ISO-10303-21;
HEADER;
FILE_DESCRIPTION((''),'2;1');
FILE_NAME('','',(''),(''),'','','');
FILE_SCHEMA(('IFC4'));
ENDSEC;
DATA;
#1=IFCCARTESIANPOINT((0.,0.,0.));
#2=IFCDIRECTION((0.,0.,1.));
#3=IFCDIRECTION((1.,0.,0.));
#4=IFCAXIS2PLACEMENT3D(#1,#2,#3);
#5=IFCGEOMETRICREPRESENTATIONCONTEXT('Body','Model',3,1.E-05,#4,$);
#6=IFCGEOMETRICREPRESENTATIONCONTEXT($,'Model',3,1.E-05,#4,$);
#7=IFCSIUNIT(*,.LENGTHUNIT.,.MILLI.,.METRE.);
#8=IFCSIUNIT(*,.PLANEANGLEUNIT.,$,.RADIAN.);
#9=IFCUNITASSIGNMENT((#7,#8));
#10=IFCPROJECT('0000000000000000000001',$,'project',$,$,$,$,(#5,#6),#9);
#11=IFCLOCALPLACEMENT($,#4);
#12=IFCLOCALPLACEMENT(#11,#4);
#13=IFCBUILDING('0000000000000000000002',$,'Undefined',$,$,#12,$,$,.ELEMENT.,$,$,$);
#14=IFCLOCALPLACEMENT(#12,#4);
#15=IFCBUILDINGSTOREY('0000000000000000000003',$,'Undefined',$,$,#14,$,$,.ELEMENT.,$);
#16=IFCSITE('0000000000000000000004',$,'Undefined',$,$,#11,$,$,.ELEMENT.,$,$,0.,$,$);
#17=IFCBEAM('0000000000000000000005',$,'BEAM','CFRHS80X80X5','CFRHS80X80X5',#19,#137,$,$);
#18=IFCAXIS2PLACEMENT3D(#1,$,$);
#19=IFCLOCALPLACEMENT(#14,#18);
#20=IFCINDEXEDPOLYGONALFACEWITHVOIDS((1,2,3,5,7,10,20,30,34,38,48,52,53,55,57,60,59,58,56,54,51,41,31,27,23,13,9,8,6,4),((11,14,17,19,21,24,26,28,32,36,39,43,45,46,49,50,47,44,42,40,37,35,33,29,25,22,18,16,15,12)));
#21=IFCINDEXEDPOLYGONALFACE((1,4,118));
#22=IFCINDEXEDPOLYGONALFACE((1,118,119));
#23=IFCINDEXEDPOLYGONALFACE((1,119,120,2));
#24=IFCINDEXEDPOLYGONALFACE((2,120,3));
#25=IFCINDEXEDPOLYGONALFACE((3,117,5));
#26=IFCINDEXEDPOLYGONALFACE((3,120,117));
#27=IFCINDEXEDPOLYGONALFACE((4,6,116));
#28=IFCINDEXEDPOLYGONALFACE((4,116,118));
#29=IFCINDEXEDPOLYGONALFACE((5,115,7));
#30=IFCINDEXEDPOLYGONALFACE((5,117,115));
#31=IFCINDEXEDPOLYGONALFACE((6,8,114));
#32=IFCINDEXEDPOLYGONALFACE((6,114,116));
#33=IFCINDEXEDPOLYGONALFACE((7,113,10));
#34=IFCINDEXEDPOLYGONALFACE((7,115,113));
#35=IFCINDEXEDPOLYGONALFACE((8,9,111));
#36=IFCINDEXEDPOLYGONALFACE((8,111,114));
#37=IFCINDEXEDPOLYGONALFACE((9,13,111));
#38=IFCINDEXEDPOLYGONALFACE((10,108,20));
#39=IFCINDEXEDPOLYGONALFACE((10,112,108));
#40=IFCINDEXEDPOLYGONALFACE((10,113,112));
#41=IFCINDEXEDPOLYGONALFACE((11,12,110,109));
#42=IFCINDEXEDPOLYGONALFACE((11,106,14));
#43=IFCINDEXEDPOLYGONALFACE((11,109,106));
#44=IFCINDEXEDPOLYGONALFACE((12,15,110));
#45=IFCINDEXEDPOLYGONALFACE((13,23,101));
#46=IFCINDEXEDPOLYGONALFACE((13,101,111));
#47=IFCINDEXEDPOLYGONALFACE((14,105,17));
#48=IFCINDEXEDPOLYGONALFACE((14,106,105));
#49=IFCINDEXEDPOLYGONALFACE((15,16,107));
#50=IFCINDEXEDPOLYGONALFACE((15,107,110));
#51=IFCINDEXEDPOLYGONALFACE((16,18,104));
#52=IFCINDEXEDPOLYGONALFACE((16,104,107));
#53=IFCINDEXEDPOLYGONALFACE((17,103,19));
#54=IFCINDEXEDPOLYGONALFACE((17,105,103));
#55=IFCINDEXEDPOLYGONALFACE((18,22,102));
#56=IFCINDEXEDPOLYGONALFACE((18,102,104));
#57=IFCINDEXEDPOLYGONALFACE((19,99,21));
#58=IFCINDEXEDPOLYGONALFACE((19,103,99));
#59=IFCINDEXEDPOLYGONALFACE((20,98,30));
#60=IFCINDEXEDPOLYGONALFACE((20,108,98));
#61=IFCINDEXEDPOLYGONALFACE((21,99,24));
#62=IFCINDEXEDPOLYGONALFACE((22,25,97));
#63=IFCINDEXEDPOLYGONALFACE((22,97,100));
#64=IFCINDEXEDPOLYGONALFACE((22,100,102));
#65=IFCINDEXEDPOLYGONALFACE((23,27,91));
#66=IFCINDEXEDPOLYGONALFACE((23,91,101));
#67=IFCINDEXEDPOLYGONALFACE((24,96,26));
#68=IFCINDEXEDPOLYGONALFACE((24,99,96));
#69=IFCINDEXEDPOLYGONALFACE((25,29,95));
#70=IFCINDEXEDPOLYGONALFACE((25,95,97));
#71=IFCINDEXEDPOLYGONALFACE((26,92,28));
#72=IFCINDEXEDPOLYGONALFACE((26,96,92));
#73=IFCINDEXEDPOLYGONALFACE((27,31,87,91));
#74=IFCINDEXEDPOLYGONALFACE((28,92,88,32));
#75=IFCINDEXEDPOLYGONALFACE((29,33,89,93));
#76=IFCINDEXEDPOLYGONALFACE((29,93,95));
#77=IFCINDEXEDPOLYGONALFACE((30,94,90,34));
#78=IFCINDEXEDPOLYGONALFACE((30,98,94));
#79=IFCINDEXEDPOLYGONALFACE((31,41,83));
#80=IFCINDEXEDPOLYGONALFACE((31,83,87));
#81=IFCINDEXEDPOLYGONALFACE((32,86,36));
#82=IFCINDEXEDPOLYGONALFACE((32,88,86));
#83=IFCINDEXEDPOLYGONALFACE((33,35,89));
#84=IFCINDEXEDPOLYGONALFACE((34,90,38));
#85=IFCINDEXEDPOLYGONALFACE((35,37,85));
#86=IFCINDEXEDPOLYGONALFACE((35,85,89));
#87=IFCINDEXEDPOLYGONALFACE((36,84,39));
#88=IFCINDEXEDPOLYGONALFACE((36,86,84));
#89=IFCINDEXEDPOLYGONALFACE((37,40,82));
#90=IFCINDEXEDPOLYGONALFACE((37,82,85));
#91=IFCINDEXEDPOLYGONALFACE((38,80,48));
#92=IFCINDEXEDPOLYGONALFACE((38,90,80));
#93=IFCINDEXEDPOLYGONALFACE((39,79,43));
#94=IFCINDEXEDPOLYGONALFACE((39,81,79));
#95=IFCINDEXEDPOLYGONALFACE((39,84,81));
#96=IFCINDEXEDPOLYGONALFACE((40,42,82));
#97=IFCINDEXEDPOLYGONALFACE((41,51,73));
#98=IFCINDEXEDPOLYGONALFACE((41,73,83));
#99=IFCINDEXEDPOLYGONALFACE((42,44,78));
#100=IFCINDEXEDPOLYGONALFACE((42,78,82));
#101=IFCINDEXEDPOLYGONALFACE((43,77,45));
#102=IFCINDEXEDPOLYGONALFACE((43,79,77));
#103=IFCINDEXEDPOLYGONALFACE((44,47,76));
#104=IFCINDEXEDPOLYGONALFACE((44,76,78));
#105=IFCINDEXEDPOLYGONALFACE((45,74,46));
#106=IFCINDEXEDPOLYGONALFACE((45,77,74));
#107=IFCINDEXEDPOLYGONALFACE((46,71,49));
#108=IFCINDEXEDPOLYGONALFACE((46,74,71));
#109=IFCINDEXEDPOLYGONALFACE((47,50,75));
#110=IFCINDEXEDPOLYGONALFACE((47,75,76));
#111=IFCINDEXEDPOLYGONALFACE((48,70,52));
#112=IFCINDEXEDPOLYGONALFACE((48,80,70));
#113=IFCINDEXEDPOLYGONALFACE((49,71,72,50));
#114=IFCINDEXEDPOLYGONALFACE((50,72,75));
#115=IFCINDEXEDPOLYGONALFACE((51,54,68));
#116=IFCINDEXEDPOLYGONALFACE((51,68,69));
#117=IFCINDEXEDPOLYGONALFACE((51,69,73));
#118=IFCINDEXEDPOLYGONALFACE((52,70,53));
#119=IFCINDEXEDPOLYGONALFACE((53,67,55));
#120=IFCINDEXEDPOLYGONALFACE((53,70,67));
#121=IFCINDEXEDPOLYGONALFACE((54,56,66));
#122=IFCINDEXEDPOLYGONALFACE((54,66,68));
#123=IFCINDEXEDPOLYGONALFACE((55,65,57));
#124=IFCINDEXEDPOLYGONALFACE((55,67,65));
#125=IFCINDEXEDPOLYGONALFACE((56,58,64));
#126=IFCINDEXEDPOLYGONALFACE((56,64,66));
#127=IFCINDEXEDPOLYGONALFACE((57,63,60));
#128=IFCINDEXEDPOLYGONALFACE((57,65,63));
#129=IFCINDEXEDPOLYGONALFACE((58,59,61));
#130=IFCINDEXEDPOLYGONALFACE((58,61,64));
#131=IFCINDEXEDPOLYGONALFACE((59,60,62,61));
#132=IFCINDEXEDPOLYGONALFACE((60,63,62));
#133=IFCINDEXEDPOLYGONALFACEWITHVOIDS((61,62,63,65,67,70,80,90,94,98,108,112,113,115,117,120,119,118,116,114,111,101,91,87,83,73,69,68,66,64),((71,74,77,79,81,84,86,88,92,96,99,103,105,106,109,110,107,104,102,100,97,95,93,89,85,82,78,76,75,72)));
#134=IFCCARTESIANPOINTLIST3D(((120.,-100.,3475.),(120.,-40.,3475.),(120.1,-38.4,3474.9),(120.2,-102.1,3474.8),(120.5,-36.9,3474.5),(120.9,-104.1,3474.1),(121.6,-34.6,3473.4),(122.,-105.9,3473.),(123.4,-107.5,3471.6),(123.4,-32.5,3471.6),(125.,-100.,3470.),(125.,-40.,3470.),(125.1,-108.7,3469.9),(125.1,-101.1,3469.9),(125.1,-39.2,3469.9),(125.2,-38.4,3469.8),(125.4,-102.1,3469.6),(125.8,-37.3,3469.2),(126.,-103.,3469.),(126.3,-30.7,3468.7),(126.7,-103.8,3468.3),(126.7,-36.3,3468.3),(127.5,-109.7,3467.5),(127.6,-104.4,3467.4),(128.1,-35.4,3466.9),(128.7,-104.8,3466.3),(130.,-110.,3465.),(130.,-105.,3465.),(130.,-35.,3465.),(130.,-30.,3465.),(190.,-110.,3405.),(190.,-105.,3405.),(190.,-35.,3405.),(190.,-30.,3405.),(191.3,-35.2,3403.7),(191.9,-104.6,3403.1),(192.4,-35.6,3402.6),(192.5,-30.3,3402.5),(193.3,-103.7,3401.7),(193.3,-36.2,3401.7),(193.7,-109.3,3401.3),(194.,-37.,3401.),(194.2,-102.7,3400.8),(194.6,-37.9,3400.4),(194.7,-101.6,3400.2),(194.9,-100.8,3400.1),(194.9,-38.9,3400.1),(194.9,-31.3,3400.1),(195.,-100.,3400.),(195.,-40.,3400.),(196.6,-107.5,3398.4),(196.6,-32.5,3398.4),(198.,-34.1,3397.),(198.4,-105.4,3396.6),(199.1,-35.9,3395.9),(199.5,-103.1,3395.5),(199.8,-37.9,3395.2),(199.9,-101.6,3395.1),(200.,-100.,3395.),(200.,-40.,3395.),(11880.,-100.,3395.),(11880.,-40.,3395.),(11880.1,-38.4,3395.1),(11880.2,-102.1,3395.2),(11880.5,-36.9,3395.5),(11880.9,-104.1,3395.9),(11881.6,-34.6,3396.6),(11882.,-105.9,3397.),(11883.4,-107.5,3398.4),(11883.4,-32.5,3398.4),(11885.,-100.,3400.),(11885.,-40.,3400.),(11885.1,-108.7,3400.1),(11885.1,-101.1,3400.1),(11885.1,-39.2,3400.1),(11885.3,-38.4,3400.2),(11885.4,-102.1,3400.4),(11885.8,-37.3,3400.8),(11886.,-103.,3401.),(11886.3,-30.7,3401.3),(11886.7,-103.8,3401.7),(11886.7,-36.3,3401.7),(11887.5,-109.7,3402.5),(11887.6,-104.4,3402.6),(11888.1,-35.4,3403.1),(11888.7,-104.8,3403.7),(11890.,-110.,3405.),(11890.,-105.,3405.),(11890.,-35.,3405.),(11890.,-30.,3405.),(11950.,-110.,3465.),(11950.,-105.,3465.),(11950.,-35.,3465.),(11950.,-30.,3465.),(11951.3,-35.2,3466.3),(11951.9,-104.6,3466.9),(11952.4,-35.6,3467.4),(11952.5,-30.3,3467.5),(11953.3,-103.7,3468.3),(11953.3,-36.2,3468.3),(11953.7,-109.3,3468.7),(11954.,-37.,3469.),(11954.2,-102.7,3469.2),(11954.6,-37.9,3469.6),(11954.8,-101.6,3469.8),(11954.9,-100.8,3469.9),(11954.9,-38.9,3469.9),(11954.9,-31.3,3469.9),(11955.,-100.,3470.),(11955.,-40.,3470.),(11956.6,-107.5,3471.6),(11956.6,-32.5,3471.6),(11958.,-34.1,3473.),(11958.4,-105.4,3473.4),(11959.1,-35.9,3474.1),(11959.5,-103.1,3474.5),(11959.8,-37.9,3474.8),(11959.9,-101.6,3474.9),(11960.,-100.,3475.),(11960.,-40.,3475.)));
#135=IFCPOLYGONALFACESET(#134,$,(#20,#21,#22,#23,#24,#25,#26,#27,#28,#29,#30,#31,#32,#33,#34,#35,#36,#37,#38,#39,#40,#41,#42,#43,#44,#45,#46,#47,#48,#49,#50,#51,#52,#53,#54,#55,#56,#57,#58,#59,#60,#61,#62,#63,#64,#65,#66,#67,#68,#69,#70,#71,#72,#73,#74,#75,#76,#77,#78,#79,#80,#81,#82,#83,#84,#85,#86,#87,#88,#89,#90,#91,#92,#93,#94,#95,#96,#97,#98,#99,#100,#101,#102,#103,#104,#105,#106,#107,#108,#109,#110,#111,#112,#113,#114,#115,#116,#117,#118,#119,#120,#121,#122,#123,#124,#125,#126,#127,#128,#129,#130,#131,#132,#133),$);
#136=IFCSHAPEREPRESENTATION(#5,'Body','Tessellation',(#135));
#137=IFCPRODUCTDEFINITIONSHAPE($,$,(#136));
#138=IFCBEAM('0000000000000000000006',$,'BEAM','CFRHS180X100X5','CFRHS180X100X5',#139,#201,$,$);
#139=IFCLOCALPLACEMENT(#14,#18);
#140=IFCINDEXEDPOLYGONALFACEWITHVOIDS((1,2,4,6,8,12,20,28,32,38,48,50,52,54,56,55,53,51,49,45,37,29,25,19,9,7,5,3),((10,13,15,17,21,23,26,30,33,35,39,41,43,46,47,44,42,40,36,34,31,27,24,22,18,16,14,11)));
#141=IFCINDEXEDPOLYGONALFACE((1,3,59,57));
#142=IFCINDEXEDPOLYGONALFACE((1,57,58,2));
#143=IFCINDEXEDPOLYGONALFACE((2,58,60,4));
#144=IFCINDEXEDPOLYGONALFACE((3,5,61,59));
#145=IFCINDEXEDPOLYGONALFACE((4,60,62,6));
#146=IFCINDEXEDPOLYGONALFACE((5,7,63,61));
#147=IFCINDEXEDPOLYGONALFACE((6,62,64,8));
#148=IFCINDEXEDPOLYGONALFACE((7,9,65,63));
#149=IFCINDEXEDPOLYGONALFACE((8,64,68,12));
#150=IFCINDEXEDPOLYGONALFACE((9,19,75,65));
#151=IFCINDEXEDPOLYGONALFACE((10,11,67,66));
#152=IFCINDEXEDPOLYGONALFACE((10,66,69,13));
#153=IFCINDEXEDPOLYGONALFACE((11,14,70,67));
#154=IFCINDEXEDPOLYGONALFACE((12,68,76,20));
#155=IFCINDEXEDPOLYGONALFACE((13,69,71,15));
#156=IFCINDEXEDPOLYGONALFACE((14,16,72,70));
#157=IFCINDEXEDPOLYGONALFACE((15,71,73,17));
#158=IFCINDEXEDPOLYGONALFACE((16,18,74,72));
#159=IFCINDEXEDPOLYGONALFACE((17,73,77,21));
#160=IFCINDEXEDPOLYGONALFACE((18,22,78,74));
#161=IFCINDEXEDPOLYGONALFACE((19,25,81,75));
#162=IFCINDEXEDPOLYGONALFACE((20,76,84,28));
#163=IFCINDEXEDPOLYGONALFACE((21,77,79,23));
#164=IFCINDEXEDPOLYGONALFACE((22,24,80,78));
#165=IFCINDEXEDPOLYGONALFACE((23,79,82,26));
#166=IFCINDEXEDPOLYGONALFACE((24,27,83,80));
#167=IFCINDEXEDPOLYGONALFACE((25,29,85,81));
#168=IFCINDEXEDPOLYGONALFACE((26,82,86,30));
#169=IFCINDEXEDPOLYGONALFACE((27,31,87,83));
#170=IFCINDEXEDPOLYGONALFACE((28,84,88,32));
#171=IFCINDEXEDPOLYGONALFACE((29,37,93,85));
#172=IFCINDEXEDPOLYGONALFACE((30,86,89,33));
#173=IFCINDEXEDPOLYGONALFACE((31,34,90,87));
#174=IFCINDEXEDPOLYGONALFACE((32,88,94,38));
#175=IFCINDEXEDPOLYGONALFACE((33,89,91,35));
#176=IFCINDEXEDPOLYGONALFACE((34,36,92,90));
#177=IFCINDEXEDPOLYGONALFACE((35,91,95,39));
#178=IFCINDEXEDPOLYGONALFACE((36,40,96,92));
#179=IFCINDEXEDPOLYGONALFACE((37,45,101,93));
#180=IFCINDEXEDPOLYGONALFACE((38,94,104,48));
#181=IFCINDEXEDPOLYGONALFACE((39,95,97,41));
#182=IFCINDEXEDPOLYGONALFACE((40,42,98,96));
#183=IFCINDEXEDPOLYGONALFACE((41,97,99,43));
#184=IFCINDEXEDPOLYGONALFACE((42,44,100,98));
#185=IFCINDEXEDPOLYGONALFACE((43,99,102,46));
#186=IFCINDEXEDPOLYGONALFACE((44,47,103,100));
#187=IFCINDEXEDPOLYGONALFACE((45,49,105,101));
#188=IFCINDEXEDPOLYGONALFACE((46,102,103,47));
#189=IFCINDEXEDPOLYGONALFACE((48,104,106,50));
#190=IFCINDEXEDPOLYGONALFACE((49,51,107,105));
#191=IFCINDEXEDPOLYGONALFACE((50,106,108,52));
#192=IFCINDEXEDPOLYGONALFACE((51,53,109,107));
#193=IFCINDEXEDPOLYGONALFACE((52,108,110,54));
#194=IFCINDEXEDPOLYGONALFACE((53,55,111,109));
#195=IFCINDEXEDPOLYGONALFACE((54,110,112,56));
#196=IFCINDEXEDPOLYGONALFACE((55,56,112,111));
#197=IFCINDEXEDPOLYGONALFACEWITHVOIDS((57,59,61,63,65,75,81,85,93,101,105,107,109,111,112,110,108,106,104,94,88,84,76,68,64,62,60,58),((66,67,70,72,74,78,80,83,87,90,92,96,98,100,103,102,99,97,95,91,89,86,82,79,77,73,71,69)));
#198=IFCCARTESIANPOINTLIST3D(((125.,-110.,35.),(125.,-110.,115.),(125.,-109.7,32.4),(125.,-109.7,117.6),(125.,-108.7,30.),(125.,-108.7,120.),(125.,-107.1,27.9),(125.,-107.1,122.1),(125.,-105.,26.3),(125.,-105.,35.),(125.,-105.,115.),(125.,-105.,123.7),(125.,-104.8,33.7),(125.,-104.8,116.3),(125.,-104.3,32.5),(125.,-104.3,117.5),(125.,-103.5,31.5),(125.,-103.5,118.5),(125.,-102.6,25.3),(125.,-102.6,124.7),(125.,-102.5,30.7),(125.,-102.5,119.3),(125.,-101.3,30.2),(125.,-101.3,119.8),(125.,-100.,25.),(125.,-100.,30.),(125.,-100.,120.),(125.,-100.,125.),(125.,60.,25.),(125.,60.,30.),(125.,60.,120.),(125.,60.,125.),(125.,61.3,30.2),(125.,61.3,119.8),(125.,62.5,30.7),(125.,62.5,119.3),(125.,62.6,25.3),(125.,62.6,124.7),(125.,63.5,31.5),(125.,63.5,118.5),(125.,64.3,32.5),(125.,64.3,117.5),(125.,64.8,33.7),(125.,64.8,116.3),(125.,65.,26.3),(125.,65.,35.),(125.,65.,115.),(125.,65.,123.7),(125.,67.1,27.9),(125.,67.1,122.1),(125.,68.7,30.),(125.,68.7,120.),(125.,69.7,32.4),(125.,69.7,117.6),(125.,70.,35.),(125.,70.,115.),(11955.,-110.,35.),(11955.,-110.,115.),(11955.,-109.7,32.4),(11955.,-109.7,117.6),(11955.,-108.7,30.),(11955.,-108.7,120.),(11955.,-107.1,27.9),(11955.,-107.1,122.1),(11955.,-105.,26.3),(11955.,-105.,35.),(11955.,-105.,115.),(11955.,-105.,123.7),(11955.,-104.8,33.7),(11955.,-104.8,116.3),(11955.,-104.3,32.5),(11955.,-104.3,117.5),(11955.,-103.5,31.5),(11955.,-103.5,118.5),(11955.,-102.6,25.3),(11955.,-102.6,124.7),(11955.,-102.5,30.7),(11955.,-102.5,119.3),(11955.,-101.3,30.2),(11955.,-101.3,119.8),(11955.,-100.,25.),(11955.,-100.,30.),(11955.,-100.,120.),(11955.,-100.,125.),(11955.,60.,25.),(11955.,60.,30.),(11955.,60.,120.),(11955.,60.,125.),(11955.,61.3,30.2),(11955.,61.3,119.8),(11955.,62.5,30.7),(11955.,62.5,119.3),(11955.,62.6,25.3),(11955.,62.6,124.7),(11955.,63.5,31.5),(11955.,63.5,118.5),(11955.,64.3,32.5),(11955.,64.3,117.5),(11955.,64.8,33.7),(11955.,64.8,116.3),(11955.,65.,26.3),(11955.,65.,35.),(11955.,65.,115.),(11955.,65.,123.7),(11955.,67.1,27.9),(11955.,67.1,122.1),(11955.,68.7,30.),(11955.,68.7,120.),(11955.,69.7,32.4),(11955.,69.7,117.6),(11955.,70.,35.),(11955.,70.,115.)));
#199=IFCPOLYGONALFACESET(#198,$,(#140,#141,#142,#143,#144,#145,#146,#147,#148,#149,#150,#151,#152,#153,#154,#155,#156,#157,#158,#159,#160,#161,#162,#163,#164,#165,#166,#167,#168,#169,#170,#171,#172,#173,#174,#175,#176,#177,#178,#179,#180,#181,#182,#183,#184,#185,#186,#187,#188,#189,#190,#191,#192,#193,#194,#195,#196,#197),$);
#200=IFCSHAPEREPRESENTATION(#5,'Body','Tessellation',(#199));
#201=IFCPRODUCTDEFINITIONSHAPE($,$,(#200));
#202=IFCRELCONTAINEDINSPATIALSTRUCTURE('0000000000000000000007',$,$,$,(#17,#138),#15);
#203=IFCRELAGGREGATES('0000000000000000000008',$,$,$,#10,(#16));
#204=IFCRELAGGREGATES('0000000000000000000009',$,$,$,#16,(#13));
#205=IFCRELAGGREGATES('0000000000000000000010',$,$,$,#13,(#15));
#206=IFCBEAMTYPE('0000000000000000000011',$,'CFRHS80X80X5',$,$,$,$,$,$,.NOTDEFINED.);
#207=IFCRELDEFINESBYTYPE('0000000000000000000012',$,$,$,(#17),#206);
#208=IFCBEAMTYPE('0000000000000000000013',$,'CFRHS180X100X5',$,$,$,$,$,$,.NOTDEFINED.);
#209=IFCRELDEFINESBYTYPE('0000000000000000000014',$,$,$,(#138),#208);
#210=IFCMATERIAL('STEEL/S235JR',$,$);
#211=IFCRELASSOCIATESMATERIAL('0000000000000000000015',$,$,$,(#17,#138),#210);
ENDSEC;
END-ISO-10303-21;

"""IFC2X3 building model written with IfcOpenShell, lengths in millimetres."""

from ifc_helpers import new_model, si_unit, frame, origin_with_axes, origin_2d_with_axis, place, context, project, spatial, hollow_rectangle, extrude, clip, halfspace, material, type_object, element, save


model = new_model("IFC2X3")

# Units and contexts
model_context_1 = context("Model", 3, precision=1e-05, world=origin_with_axes(), identifier="Body")
model_context_2 = context("Model", 3, precision=1e-05, world=origin_with_axes())
ifc_project = project(units=[si_unit("LENGTHUNIT", "METRE", prefix="MILLI"), si_unit("PLANEANGLEUNIT", "RADIAN")], contexts=[model_context_1, model_context_2])

# Site, building, storey
site_placement = place(None, origin_with_axes())
site = spatial("IfcSite", under=ifc_project, at=site_placement, Name="Undefined", CompositionType="ELEMENT", RefElevation=0.0)
building_placement = place(site_placement, origin_with_axes())
building = spatial("IfcBuilding", under=site, at=building_placement, Name="Undefined", CompositionType="ELEMENT")
storey_placement = place(building_placement, origin_with_axes())
storey = spatial("IfcBuildingStorey", under=building, at=storey_placement, Name="Undefined", CompositionType="ELEMENT")

# Shared definitions
ifc_material = material(Name="STEEL/S235JR")

# Beams
beam_type_1 = type_object("IfcBeamType", Name="CFRHS80X80X5", PredefinedType="NOTDEFINED")
beam_1_placement = place(storey_placement, frame((120.0, -70.0, 3435.0), z_axis=(0.0, -1.0, 0.0), x_axis=(1.0, 0.0, 0.0)))
element("IfcBeam", 1, at=beam_1_placement, inside=storey, type_object=beam_type_1, material=ifc_material, Name="BEAM", Description="CFRHS80X80X5", ObjectType="CFRHS80X80X5", context=model_context_1, shape_type="Clipping", body=[
    clip(clip(extrude(hollow_rectangle(XDim=80.0, YDim=80.0, WallThickness=5.0, InnerFilletRadius=5.0, OuterFilletRadius=10.0, at=origin_2d_with_axis()), frame((11880.8, 0.0, 0.0), z_axis=(-1.0, 0.0, 0.0), x_axis=(0.0, -1.0, 0.0)), (0.0, 0.0, 1.0), 11921.6), halfspace(frame((11840.0, 40.0, -70.0), z_axis=(-0.707111, 0.707103, 0.0), x_axis=(0.0, 0.0, 1.0)), True)), halfspace(frame((0.0, 40.0, -70.0), z_axis=(0.707111, 0.707103, 0.0), x_axis=(0.707103, -0.707111, 0.0)), True)),
])
beam_type_2 = type_object("IfcBeamType", Name="CFRHS180X100X5", PredefinedType="NOTDEFINED")
beam_2_placement = place(storey_placement, frame((125.0, -20.0, 75.0), z_axis=(0.0, -1.0, 0.0), x_axis=(1.0, 0.0, 0.0)))
element("IfcBeam", 2, at=beam_2_placement, inside=storey, type_object=beam_type_2, material=ifc_material, Name="BEAM", Description="CFRHS180X100X5", ObjectType="CFRHS180X100X5", context=model_context_1, shape_type="SweptSolid", body=[
    extrude(hollow_rectangle(XDim=100.0, YDim=180.0, WallThickness=5.0, InnerFilletRadius=5.0, OuterFilletRadius=10.0, at=origin_2d_with_axis()), frame((11830.0, 0.0, 0.0), z_axis=(-1.0, 0.0, 0.0), x_axis=(0.0, -1.0, 0.0)), (0.0, 0.0, 1.0), 11830.0),
])

save(model, "model.ifc")
